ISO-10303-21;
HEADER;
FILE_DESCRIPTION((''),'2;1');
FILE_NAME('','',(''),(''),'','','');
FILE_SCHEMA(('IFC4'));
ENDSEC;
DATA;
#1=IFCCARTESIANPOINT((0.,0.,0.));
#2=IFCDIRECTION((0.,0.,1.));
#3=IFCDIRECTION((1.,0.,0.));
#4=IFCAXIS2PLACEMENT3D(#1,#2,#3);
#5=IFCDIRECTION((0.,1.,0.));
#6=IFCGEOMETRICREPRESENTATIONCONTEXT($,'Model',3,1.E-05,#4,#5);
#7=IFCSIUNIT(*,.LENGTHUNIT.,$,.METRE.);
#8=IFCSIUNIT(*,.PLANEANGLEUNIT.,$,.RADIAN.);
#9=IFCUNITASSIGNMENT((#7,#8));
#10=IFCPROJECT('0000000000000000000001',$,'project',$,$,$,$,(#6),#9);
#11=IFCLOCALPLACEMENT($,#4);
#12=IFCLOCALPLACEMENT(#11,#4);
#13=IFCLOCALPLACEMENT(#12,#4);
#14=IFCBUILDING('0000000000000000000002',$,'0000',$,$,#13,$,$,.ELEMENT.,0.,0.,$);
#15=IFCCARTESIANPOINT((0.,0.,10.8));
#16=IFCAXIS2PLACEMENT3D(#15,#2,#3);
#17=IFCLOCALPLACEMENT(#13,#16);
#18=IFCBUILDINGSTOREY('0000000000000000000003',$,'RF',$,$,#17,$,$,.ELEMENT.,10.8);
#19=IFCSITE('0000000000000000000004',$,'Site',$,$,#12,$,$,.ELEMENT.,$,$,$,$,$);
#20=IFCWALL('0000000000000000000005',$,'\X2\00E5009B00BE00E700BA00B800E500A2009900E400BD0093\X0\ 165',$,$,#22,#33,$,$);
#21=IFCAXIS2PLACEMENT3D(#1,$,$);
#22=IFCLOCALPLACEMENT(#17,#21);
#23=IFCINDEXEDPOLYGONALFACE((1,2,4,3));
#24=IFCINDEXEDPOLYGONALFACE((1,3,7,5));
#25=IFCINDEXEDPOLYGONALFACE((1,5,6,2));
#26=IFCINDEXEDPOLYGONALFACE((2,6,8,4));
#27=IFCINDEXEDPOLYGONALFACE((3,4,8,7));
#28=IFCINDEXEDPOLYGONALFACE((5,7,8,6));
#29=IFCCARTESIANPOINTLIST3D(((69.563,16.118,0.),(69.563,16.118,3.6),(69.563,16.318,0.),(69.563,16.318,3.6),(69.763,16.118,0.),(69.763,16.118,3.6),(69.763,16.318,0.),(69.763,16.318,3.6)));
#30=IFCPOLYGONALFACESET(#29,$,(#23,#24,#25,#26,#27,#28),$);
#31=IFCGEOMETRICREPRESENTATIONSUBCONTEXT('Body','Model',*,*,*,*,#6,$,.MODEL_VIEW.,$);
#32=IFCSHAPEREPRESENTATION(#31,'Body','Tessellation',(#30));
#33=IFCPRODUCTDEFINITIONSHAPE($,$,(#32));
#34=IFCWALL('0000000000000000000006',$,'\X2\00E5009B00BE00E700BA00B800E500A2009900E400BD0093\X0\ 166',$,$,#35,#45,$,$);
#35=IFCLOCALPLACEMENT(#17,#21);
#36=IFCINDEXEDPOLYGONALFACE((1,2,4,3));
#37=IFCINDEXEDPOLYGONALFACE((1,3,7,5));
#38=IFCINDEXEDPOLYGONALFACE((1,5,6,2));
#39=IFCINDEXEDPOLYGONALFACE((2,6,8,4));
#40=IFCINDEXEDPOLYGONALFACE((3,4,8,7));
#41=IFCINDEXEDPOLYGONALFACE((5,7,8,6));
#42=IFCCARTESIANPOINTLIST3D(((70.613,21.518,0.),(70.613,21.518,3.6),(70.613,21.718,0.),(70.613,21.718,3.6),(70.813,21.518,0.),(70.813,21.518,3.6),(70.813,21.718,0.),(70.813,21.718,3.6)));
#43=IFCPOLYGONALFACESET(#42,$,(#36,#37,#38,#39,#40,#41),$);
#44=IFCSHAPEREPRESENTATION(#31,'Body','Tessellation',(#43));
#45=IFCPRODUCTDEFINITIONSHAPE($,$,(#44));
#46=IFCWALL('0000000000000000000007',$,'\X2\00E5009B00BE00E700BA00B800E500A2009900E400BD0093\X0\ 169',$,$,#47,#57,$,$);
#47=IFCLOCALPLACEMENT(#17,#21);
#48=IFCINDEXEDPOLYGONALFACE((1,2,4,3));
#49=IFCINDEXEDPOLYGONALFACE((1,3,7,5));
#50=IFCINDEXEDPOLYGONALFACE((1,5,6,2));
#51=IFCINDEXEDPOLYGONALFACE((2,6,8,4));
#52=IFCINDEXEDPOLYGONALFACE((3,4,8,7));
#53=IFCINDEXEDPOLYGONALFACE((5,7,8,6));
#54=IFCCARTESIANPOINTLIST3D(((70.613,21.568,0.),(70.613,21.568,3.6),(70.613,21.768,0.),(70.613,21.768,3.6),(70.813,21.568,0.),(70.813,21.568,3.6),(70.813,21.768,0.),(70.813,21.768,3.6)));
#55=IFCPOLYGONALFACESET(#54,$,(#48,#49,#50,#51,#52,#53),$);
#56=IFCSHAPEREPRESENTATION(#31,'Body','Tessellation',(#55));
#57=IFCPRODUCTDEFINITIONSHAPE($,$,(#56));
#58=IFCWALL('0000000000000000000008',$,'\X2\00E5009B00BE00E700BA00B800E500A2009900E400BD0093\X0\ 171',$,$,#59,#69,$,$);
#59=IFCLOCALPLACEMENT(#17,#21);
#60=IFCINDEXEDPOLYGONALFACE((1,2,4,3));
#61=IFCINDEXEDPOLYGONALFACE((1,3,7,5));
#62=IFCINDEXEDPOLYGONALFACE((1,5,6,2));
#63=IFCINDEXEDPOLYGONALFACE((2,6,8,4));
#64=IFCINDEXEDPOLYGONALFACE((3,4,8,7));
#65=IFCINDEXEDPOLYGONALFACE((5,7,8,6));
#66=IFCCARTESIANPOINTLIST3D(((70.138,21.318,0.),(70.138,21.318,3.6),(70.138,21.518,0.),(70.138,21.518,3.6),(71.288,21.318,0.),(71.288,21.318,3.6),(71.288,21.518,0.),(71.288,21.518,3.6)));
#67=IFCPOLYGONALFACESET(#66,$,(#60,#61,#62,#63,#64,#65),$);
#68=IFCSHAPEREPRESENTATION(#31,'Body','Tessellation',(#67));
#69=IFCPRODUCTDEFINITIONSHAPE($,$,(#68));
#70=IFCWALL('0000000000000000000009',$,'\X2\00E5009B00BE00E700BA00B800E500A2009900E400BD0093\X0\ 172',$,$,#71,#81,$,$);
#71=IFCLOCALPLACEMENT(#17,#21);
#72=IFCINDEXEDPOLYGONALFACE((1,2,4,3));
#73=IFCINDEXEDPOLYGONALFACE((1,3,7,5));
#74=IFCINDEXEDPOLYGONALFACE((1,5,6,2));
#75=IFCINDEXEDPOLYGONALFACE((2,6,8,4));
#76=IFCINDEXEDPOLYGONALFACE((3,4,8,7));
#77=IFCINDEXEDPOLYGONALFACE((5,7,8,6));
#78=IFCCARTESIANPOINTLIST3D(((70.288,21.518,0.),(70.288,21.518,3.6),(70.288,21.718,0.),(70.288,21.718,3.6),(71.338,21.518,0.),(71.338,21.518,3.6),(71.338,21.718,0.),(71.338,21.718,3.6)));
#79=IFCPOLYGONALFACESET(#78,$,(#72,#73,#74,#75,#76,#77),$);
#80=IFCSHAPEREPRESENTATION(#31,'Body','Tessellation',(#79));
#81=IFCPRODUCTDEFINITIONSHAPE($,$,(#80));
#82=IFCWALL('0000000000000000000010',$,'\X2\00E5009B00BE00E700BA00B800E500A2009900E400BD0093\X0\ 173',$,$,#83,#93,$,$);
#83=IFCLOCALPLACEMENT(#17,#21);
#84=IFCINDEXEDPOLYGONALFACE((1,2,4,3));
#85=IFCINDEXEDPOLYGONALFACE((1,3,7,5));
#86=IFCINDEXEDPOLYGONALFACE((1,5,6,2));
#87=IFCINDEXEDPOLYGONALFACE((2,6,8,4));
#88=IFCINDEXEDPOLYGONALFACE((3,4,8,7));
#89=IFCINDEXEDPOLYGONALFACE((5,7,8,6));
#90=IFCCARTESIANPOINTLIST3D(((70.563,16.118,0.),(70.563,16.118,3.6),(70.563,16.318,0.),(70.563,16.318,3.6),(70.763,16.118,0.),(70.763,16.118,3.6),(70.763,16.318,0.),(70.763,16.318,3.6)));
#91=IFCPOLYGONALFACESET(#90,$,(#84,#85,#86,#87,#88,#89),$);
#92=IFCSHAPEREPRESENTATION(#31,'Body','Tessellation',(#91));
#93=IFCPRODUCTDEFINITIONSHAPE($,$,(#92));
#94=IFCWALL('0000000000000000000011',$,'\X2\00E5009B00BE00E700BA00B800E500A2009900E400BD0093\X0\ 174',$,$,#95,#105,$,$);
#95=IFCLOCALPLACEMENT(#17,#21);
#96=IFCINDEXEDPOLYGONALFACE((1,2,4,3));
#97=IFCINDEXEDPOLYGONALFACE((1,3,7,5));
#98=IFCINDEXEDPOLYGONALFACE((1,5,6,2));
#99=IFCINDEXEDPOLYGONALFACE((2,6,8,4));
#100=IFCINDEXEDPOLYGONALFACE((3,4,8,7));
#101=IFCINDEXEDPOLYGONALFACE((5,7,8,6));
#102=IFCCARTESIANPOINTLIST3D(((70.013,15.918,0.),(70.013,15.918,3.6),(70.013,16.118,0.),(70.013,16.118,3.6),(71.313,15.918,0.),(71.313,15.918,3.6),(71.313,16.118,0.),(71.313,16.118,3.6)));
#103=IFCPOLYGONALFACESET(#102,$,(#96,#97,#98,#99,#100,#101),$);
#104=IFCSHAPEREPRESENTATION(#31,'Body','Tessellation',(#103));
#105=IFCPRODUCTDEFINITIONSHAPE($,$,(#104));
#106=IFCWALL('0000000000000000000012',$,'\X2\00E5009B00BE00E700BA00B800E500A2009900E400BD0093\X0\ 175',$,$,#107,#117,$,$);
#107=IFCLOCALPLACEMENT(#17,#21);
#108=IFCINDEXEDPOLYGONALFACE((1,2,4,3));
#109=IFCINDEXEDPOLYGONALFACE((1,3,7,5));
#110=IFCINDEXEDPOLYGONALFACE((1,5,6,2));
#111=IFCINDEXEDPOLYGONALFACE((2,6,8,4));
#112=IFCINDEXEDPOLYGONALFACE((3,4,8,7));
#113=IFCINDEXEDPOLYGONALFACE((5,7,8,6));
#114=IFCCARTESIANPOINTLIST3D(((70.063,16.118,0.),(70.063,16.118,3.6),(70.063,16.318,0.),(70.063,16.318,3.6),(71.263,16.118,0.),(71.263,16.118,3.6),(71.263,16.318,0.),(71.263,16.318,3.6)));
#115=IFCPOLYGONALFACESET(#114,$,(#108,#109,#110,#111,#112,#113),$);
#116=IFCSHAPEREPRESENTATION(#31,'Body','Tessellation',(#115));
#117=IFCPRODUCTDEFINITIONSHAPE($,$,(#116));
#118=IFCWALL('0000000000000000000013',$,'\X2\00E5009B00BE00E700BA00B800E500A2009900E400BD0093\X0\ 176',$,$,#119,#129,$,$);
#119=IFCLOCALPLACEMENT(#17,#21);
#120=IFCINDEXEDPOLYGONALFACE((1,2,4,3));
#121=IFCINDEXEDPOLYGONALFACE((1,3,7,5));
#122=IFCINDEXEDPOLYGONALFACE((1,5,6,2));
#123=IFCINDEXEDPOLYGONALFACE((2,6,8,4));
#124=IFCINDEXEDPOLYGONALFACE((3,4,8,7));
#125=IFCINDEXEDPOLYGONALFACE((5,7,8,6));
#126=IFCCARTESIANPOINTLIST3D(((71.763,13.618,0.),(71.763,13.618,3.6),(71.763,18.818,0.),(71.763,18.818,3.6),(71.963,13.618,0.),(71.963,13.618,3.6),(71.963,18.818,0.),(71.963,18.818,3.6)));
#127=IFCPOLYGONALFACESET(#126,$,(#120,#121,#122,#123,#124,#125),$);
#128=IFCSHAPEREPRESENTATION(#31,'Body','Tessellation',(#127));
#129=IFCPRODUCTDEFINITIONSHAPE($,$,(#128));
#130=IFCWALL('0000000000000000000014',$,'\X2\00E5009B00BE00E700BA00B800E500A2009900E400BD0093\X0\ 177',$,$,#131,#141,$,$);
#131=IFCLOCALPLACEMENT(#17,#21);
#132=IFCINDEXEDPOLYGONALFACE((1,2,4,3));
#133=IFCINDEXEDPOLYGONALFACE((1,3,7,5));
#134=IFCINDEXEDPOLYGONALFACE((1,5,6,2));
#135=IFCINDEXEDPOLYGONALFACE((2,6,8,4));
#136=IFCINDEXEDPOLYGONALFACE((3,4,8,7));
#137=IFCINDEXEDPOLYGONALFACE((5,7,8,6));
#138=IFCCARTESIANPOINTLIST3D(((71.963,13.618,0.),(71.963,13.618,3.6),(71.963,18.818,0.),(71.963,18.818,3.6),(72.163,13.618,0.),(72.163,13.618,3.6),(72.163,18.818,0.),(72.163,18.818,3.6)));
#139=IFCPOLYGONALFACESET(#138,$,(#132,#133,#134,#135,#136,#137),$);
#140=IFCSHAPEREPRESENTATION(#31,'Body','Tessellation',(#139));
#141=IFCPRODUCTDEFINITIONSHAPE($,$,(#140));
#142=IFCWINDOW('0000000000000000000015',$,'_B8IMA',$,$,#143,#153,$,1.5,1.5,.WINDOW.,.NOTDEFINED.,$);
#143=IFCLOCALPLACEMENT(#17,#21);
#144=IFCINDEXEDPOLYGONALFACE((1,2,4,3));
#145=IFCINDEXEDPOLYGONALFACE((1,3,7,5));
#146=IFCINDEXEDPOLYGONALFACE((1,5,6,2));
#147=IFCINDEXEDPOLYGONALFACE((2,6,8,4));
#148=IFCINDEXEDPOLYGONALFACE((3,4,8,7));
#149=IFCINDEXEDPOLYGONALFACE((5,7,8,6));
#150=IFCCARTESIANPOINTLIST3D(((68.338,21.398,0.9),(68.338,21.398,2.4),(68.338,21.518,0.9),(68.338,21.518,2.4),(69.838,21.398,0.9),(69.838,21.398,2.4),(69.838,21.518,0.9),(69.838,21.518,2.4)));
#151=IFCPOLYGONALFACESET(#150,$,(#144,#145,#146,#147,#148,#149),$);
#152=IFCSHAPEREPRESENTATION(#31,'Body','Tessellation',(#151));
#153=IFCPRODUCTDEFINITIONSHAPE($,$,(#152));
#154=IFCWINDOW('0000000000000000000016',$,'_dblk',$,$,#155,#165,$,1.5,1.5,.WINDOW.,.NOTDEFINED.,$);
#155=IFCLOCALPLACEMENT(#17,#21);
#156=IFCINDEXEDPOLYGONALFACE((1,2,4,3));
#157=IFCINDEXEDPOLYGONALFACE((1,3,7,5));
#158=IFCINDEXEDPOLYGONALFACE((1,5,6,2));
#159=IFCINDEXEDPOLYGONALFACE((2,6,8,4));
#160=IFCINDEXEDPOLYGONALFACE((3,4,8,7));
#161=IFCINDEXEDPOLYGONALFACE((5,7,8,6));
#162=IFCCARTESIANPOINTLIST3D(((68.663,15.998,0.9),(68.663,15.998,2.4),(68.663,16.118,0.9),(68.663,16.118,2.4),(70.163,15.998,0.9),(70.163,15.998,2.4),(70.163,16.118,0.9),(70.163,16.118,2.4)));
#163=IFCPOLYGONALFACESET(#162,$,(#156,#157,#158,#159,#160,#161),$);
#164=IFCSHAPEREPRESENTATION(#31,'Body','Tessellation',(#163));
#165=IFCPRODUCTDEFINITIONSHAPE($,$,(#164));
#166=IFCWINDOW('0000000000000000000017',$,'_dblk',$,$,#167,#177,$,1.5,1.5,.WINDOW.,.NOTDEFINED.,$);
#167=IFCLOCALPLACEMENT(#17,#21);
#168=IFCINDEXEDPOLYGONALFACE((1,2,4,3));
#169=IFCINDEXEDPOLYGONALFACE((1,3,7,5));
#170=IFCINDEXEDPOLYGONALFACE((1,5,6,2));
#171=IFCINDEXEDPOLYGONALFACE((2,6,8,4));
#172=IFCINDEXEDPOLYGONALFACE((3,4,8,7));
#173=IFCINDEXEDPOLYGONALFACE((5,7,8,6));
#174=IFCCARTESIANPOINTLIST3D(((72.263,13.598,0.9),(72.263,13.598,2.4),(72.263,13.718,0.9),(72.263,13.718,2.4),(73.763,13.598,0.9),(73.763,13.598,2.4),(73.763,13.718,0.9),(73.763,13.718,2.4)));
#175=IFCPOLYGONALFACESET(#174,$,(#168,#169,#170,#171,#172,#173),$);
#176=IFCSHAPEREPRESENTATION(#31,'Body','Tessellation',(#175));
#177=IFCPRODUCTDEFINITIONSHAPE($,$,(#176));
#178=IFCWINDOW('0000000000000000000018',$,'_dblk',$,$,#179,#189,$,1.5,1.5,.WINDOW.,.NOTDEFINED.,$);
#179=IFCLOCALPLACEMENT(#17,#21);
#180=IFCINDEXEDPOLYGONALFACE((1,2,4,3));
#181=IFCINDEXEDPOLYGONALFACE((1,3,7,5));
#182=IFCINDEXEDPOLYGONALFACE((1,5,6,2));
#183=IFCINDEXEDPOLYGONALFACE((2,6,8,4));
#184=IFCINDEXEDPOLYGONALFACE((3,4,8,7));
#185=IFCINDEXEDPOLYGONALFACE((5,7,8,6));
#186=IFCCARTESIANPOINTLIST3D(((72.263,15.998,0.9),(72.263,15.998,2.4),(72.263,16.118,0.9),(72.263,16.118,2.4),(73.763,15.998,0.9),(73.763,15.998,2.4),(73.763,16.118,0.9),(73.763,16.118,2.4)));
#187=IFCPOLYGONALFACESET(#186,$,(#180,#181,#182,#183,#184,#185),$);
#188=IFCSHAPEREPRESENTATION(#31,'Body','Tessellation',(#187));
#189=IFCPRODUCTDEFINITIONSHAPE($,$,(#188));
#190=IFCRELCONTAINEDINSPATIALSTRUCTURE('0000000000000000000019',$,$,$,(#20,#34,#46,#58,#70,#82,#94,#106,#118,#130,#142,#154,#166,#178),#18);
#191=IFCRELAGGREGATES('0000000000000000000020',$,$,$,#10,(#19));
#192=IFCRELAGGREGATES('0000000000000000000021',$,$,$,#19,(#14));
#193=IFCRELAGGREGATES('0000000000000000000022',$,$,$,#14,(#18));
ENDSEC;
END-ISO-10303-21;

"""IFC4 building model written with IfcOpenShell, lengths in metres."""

from ifc_helpers import new_model, si_unit, direction, frame, frame_2d, origin_with_axes, place, context, subcontext, project, spatial, rectangle, extrude, element, save


model = new_model("IFC4")

# Units and contexts
model_context = context("Model", 3, precision=1e-05, world=origin_with_axes(), true_north=direction((0.0, 1.0, 0.0)))
body_context = subcontext(model_context, "Body", "Model", "MODEL_VIEW")
ifc_project = project(units=[si_unit("LENGTHUNIT", "METRE"), si_unit("PLANEANGLEUNIT", "RADIAN")], contexts=[model_context])

# Site, building, storey
placement = place(None, origin_with_axes())
site_placement = place(placement, origin_with_axes())
site = spatial("IfcSite", under=ifc_project, at=site_placement, Name="Site", CompositionType="ELEMENT")
building_placement = place(site_placement, origin_with_axes())
building = spatial("IfcBuilding", under=site, at=building_placement, Name="0000", CompositionType="ELEMENT", ElevationOfRefHeight=0.0, ElevationOfTerrain=0.0)
storey_placement = place(building_placement, frame((0.0, 0.0, 10.8), z_axis=(0.0, 0.0, 1.0), x_axis=(1.0, 0.0, 0.0)))
storey = spatial("IfcBuildingStorey", under=building, at=storey_placement, Name="RF", CompositionType="ELEMENT", Elevation=10.8)

# Walls
for number, where, z_axis, x_axis, name in (
    (1, (69.663, 16.218, 0.0), (0.0, 0.0, 1.0), (0.0, -1.0, 0.0), "å\u009b¾çº¸å¢\u0099ä½\u0093 165"),
    (2, (70.713, 21.618, 0.0), (0.0, 0.0, 1.0), (0.0, -1.0, 0.0), "å\u009b¾çº¸å¢\u0099ä½\u0093 166"),
    (3, (70.713, 21.668, 0.0), (0.0, 0.0, 1.0), (0.0, -1.0, 0.0), "å\u009b¾çº¸å¢\u0099ä½\u0093 169"),
):
    element("IfcWall", number, at=place(storey_placement, frame(where, z_axis=z_axis, x_axis=x_axis)), inside=storey, Name=name, context=body_context, shape_type="SweptSolid", body=[
        extrude(rectangle(XDim=0.2, YDim=0.2, at=frame_2d((0.0, 0.0), x_axis=(1.0, 0.0, 0.0))), frame((0.0, 0.0, 0.0), z_axis=(0.0, 0.0, 1.0)), (0.0, 0.0, 1.0), 3.6),
    ])
wall_1_placement = place(storey_placement, frame((70.713, 21.418, 0.0), z_axis=(0.0, 0.0, 1.0), x_axis=(1.0, 0.0, 0.0)))
element("IfcWall", 4, at=wall_1_placement, inside=storey, Name="å\u009b¾çº¸å¢\u0099ä½\u0093 171", context=body_context, shape_type="SweptSolid", body=[
    extrude(rectangle(XDim=1.15, YDim=0.2, at=frame_2d((0.0, 0.0), x_axis=(1.0, 0.0, 0.0))), frame((0.0, 0.0, 0.0), z_axis=(0.0, 0.0, 1.0)), (0.0, 0.0, 1.0), 3.6),
])
wall_2_placement = place(storey_placement, frame((70.813, 21.618, 0.0), z_axis=(0.0, 0.0, 1.0), x_axis=(1.0, 0.0, 0.0)))
element("IfcWall", 5, at=wall_2_placement, inside=storey, Name="å\u009b¾çº¸å¢\u0099ä½\u0093 172", context=body_context, shape_type="SweptSolid", body=[
    extrude(rectangle(XDim=1.05, YDim=0.2, at=frame_2d((0.0, 0.0), x_axis=(1.0, 0.0, 0.0))), frame((0.0, 0.0, 0.0), z_axis=(0.0, 0.0, 1.0)), (0.0, 0.0, 1.0), 3.6),
])
wall_3_placement = place(storey_placement, frame((70.663, 16.218, 0.0), z_axis=(0.0, 0.0, 1.0), x_axis=(0.0, -1.0, 0.0)))
element("IfcWall", 6, at=wall_3_placement, inside=storey, Name="å\u009b¾çº¸å¢\u0099ä½\u0093 173", context=body_context, shape_type="SweptSolid", body=[
    extrude(rectangle(XDim=0.2, YDim=0.2, at=frame_2d((0.0, 0.0), x_axis=(1.0, 0.0, 0.0))), frame((0.0, 0.0, 0.0), z_axis=(0.0, 0.0, 1.0)), (0.0, 0.0, 1.0), 3.6),
])
wall_4_placement = place(storey_placement, frame((70.663, 16.018, 0.0), z_axis=(0.0, 0.0, 1.0), x_axis=(1.0, 0.0, 0.0)))
element("IfcWall", 7, at=wall_4_placement, inside=storey, Name="å\u009b¾çº¸å¢\u0099ä½\u0093 174", context=body_context, shape_type="SweptSolid", body=[
    extrude(rectangle(XDim=1.3, YDim=0.2, at=frame_2d((0.0, 0.0), x_axis=(1.0, 0.0, 0.0))), frame((0.0, 0.0, 0.0), z_axis=(0.0, 0.0, 1.0)), (0.0, 0.0, 1.0), 3.6),
])
wall_5_placement = place(storey_placement, frame((70.663, 16.218, 0.0), z_axis=(0.0, 0.0, 1.0), x_axis=(1.0, 0.0, 0.0)))
element("IfcWall", 8, at=wall_5_placement, inside=storey, Name="å\u009b¾çº¸å¢\u0099ä½\u0093 175", context=body_context, shape_type="SweptSolid", body=[
    extrude(rectangle(XDim=1.2, YDim=0.2, at=frame_2d((0.0, 0.0), x_axis=(1.0, 0.0, 0.0))), frame((0.0, 0.0, 0.0), z_axis=(0.0, 0.0, 1.0)), (0.0, 0.0, 1.0), 3.6),
])
for number, where, z_axis, x_axis, name in (
    (9, (71.863, 16.218, 0.0), (0.0, 0.0, 1.0), (0.0, 1.0, 0.0), "å\u009b¾çº¸å¢\u0099ä½\u0093 176"),
    (10, (72.063, 16.218, 0.0), (0.0, 0.0, 1.0), (0.0, 1.0, 0.0), "å\u009b¾çº¸å¢\u0099ä½\u0093 177"),
):
    element("IfcWall", number, at=place(storey_placement, frame(where, z_axis=z_axis, x_axis=x_axis)), inside=storey, Name=name, context=body_context, shape_type="SweptSolid", body=[
        extrude(rectangle(XDim=5.2, YDim=0.2, at=frame_2d((0.0, 0.0), x_axis=(1.0, 0.0, 0.0))), frame((0.0, 0.0, 0.0), z_axis=(0.0, 0.0, 1.0)), (0.0, 0.0, 1.0), 3.6),
    ])

# Windows
for number, where, z_axis, x_axis, name in (
    (11, (69.088, 21.458, 0.9), (0.0, 0.0, 1.0), (1.0, 0.0, 0.0), "_B8IMA"),
    (12, (69.413, 16.058, 0.9), (0.0, 0.0, 1.0), (1.0, 0.0, 0.0), "_dblk"),
    (13, (73.013, 13.658, 0.9), (0.0, 0.0, 1.0), (1.0, 0.0, 0.0), "_dblk"),
    (14, (73.013, 16.058, 0.9), (0.0, 0.0, 1.0), (1.0, 0.0, 0.0), "_dblk"),
):
    element("IfcWindow", number, at=place(storey_placement, frame(where, z_axis=z_axis, x_axis=x_axis)), inside=storey, Name=name, OverallHeight=1.5, OverallWidth=1.5, PartitioningType="NOTDEFINED", PredefinedType="WINDOW", context=body_context, shape_type="SweptSolid", body=[
        extrude(rectangle(XDim=1.5, YDim=0.12, at=frame_2d((0.0, 0.0), x_axis=(1.0, 0.0, 0.0))), frame((0.0, 0.0, 0.0), z_axis=(0.0, 0.0, 1.0)), (0.0, 0.0, 1.0), 1.5),
    ])

save(model, "model.ifc")
